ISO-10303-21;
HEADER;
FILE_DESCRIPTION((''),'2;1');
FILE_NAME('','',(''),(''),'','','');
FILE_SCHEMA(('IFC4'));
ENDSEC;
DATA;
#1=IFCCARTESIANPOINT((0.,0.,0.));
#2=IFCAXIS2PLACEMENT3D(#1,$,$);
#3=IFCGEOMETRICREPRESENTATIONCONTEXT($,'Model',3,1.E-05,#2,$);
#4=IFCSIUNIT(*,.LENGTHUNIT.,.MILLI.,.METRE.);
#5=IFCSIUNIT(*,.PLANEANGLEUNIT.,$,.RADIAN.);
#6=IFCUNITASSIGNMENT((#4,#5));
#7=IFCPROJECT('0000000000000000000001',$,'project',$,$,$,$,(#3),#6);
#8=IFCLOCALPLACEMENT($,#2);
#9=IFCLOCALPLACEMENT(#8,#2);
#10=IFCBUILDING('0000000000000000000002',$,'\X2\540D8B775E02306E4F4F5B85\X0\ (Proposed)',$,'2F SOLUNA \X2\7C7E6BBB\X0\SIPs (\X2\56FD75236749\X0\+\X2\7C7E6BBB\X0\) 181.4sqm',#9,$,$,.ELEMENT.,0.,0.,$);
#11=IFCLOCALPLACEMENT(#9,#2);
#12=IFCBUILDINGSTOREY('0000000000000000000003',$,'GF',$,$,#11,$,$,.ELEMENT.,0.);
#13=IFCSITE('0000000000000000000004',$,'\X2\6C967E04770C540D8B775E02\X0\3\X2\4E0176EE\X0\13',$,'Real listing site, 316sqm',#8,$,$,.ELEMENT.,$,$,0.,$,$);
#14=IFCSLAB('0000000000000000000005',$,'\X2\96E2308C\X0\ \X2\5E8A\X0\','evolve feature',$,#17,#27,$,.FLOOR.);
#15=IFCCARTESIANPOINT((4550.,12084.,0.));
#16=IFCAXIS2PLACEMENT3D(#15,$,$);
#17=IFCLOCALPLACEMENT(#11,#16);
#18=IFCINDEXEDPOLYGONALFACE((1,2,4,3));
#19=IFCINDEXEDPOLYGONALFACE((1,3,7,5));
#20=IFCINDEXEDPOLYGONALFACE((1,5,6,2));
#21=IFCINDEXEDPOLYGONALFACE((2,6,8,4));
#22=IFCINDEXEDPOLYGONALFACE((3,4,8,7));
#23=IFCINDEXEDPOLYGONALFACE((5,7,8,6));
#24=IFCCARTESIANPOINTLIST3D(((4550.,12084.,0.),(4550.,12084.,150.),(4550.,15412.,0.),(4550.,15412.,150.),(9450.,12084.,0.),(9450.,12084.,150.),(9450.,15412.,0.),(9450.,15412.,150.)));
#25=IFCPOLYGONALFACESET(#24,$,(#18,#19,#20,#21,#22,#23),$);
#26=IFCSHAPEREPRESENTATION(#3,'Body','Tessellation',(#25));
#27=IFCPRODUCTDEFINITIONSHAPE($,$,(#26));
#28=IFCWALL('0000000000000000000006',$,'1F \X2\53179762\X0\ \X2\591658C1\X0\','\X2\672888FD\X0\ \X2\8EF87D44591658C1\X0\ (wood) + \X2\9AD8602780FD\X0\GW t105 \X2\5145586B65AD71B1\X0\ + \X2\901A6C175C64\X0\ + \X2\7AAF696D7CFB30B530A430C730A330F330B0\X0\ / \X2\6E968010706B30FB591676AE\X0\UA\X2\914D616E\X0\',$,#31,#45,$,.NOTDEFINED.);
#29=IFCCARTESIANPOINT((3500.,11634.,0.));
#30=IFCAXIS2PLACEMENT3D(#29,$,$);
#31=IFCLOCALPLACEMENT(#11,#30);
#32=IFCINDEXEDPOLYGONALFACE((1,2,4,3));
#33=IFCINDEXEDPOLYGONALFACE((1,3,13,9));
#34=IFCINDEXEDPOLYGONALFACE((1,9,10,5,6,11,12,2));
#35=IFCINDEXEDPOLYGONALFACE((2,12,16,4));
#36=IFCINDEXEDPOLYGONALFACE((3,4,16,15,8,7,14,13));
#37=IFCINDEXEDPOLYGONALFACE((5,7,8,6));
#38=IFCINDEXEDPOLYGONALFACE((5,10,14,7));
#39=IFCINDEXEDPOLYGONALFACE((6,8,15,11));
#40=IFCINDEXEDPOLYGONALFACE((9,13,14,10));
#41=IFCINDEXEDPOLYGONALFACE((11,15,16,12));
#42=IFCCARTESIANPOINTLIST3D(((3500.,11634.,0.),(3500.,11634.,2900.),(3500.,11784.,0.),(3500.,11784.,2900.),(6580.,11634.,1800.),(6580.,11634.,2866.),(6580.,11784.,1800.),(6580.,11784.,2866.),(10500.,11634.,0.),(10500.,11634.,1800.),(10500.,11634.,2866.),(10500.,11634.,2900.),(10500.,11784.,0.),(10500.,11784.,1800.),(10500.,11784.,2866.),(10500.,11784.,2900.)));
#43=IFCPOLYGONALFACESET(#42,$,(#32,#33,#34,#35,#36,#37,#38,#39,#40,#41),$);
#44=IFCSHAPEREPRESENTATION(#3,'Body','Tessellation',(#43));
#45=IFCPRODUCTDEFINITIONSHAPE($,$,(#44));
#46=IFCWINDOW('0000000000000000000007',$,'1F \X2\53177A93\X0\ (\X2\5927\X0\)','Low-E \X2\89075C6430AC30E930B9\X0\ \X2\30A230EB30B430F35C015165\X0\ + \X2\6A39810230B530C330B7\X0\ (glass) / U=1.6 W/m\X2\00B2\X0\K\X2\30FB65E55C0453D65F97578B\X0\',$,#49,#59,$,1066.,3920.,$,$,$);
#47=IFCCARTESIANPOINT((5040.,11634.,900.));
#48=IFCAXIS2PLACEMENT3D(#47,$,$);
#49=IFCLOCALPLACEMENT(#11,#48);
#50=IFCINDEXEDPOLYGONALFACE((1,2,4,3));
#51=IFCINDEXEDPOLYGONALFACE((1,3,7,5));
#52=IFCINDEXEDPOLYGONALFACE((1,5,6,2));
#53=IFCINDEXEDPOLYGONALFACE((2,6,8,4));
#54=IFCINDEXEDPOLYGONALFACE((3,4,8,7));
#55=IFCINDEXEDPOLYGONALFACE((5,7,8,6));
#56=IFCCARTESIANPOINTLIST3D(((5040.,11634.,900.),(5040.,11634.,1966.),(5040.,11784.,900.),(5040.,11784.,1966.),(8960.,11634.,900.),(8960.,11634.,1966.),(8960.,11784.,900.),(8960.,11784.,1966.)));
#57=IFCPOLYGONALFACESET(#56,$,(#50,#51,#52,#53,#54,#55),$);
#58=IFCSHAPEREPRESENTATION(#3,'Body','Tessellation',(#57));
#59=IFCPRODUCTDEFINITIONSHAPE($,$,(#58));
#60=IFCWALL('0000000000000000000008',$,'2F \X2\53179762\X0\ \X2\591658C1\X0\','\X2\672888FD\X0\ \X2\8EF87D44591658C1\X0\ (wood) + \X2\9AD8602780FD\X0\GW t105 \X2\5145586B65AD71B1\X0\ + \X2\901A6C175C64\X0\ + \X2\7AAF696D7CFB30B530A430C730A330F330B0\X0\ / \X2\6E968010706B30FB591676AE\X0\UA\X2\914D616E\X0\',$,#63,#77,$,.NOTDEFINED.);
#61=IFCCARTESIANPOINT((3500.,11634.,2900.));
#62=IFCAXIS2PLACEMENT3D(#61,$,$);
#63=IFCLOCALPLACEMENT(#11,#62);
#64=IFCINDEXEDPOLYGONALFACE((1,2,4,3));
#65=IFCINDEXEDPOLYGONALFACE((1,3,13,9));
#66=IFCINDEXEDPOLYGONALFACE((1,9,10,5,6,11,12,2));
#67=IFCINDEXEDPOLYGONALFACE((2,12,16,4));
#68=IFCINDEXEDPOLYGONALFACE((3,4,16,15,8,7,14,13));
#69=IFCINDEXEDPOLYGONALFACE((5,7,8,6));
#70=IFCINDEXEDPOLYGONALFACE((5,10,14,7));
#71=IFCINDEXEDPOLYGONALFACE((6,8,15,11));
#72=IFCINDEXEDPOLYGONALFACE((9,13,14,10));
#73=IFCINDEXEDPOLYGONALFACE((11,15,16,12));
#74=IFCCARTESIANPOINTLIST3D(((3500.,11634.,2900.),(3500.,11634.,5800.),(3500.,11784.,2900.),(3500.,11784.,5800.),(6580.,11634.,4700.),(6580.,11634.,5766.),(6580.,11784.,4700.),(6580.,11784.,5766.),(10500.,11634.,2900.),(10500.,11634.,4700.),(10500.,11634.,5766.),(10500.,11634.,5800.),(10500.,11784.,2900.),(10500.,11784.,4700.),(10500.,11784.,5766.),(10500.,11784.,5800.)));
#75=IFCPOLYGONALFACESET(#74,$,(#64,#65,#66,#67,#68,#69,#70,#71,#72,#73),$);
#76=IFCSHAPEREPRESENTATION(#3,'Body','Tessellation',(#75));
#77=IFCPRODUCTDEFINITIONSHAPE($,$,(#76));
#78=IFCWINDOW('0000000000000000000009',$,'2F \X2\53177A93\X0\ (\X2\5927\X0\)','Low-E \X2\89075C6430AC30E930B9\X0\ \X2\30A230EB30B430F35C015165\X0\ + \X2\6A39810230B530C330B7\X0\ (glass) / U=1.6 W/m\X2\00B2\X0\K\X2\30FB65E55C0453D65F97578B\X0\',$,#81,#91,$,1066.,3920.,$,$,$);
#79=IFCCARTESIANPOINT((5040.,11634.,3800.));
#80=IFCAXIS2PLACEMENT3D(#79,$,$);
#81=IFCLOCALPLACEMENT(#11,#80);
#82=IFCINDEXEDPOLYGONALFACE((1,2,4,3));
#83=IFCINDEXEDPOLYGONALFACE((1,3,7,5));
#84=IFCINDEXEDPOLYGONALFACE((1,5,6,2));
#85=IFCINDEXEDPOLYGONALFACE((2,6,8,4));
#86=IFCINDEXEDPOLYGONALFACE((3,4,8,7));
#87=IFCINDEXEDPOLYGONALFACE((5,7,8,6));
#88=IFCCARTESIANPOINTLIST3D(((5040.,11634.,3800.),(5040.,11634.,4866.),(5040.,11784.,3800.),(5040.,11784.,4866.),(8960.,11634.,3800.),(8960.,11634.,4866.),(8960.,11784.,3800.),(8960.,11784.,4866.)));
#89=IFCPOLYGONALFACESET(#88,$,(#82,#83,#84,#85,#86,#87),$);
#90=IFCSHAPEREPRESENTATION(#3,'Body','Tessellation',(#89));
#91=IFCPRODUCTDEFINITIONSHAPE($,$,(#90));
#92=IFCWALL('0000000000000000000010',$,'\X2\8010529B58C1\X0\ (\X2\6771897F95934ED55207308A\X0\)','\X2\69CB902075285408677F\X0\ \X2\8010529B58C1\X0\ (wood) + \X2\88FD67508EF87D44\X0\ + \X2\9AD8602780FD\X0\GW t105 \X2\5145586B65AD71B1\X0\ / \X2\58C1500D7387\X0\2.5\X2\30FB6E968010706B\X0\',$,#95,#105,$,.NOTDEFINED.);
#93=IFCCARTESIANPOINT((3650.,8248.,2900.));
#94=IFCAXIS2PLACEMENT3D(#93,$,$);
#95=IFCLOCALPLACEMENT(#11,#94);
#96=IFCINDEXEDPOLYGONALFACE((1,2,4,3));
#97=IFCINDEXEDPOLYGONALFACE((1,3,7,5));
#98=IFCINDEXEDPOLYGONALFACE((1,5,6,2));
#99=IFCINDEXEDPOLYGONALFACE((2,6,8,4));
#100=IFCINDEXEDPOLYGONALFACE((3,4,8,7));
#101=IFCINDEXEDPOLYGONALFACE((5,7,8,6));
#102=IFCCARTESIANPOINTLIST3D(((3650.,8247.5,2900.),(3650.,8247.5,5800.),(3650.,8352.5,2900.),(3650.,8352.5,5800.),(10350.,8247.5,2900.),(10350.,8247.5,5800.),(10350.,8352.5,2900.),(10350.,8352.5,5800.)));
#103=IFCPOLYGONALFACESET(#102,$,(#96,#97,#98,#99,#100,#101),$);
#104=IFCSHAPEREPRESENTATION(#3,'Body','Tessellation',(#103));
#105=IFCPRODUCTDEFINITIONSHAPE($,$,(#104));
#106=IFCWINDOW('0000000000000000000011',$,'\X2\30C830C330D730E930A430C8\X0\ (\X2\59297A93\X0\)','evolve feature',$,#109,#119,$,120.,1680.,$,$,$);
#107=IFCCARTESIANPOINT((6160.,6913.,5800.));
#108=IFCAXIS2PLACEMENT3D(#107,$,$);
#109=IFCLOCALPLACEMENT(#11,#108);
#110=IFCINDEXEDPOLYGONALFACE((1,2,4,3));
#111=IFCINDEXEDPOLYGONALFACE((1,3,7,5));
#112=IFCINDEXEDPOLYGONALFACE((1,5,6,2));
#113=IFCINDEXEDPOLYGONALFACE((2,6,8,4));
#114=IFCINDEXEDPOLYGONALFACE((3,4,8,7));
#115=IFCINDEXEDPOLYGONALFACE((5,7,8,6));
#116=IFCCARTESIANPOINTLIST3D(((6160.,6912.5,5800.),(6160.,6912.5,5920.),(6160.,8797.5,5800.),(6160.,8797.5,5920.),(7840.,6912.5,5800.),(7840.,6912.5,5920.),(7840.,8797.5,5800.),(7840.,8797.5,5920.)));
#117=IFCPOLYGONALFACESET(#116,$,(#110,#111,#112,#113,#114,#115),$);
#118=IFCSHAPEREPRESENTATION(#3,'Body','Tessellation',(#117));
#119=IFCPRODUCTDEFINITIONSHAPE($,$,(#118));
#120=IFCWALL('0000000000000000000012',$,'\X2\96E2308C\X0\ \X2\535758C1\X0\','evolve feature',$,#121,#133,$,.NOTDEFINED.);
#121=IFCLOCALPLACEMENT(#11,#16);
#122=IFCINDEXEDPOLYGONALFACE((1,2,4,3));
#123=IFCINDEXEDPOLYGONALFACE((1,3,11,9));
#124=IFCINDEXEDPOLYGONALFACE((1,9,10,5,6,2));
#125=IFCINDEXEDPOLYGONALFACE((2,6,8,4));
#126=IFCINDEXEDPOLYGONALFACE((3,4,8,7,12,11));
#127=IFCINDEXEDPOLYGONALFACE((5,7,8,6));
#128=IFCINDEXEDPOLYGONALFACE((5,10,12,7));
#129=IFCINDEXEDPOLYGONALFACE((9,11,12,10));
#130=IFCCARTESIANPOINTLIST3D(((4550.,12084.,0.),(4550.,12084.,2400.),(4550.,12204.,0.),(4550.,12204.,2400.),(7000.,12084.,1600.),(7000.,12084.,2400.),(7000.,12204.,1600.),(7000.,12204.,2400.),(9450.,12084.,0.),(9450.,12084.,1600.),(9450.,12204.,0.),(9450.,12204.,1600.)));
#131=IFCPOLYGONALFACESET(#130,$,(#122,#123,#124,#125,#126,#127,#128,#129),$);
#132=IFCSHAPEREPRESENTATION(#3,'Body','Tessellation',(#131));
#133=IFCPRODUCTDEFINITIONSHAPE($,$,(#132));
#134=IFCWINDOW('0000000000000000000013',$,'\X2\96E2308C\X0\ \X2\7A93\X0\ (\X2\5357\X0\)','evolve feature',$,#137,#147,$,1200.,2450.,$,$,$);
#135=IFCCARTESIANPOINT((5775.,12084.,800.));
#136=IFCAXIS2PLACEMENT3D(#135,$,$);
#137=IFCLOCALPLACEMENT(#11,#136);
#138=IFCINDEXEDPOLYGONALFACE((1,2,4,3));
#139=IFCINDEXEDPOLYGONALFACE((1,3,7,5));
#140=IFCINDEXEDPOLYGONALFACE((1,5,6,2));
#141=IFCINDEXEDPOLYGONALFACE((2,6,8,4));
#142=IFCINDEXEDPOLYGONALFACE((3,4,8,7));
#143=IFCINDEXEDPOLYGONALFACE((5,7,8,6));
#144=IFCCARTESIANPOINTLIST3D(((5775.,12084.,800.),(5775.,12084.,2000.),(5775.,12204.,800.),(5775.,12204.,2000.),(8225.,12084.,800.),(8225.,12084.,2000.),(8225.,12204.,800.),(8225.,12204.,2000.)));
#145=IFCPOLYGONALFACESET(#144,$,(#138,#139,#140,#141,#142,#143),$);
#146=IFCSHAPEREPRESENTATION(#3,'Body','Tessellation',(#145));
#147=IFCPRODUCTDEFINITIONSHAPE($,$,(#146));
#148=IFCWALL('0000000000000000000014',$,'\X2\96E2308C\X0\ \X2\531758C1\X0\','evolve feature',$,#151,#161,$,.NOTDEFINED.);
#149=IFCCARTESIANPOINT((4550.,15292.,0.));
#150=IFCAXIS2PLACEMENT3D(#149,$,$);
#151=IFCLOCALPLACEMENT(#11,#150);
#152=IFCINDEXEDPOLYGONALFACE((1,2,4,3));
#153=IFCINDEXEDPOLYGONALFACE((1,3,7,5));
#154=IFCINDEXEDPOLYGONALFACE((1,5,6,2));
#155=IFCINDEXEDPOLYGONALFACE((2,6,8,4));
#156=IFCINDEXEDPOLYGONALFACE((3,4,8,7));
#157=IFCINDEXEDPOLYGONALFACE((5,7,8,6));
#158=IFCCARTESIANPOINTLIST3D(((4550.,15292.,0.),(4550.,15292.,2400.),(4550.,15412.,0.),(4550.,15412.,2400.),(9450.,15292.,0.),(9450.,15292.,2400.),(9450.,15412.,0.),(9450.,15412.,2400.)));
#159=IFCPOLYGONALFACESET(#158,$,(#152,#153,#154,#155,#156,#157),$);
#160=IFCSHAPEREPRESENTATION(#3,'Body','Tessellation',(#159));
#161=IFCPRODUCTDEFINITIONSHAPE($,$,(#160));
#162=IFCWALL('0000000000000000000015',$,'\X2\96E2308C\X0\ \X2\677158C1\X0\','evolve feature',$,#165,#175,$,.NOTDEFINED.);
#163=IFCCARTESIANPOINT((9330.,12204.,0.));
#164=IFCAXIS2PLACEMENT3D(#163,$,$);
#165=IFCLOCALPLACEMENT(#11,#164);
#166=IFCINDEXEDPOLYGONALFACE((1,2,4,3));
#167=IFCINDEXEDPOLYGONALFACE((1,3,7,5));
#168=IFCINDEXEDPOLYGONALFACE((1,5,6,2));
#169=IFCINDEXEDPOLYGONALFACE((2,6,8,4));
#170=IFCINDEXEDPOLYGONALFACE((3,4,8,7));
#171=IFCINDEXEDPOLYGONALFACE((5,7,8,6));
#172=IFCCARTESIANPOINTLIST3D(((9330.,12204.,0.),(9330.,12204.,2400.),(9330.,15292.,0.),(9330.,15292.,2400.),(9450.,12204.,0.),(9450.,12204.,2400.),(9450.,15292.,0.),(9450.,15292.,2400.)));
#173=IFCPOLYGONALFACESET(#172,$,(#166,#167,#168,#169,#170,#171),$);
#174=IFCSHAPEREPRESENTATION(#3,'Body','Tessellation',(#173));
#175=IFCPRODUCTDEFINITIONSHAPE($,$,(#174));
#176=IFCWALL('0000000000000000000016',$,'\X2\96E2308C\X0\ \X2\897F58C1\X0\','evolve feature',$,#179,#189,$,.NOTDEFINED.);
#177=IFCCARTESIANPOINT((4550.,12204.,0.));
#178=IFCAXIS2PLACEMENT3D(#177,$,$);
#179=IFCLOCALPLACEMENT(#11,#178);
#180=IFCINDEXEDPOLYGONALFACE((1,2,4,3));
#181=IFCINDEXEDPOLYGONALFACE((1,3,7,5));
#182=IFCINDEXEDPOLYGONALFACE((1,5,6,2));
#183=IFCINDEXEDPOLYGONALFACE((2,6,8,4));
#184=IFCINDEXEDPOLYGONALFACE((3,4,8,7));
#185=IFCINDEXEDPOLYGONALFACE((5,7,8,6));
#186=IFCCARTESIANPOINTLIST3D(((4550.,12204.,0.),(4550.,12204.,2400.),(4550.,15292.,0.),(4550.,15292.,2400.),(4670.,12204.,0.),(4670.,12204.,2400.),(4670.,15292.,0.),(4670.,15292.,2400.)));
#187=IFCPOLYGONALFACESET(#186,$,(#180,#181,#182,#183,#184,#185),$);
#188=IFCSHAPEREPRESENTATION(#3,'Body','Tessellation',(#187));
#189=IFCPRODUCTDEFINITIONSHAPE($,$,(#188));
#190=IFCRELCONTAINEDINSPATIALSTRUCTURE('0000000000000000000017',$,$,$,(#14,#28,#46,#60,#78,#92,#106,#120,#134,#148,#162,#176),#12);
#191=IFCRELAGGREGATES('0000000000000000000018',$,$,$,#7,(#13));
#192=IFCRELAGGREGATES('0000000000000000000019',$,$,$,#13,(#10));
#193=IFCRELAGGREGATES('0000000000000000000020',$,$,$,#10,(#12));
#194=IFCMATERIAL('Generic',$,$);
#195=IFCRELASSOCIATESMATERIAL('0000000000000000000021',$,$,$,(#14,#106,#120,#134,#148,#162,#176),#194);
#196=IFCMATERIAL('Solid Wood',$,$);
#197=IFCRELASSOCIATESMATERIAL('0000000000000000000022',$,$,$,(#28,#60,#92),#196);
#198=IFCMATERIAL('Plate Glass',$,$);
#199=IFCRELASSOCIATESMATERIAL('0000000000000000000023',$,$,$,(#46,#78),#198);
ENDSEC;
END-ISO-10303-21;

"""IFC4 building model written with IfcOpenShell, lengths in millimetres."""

from ifc_helpers import new_model, si_unit, frame, frame_2d, origin, place, context, project, spatial, rectangle, extrude, material, element, fill, save


model = new_model("IFC4")

# Units and contexts
model_context = context("Model", 3, precision=1e-05, world=origin())
ifc_project = project(units=[si_unit("LENGTHUNIT", "METRE", prefix="MILLI"), si_unit("PLANEANGLEUNIT", "RADIAN")], contexts=[model_context])

# Site, building, storey
site_placement = place(None, origin())
site = spatial("IfcSite", under=ifc_project, at=site_placement, Name="沖縄県名護市3丁目13", ObjectType="Real listing site, 316sqm", CompositionType="ELEMENT", RefElevation=0.0)
building_placement = place(site_placement, origin())
building = spatial("IfcBuilding", under=site, at=building_placement, Name="名護市の住宅 (Proposed)", ObjectType="2F SOLUNA 籾殻SIPs (国産杉+籾殻) 181.4sqm", CompositionType="ELEMENT", ElevationOfRefHeight=0.0, ElevationOfTerrain=0.0)
storey_placement = place(building_placement, origin())
storey = spatial("IfcBuildingStorey", under=building, at=storey_placement, Name="GF", CompositionType="ELEMENT", Elevation=0.0)

# Slab
ifc_material_1 = material(Name="Generic")
slab_placement = place(storey_placement, frame((4550.0, 12084.0, 0.0)))
element("IfcSlab", 1, at=slab_placement, inside=storey, material=ifc_material_1, Name="離れ 床", Description="evolve feature", PredefinedType="FLOOR", context=model_context, shape_type="SweptSolid", body=[
    extrude(rectangle(XDim=4900.0, YDim=3328.0, at=frame_2d((2450.0, 1664.0))), frame((4550.0, 12084.0, 0.0)), (0.0, 0.0, 1.0), 150.0),
])

# Wall, opening, window
ifc_material_2 = material(Name="Solid Wood")
wall_1_placement = place(storey_placement, frame((3500.0, 11634.0, 0.0)))
wall_1 = element("IfcWall", 2, at=wall_1_placement, inside=storey, material=ifc_material_2, Name="1F 北面 外壁", Description="木製 軸組外壁 (wood) + 高性能GW t105 充填断熱 + 通気層 + 窯業系サイディング / 準耐火・外皮UA配慮", PredefinedType="NOTDEFINED", context=model_context, shape_type="SweptSolid", body=[
    extrude(rectangle(XDim=7000.0, YDim=150.0, at=frame_2d((3500.0, 75.0))), frame((3500.0, 11634.0, 0.0)), (0.0, 0.0, 1.0), 2900.0),
])
opening_1_placement = place(storey_placement, frame((5040.0, 11634.0, 900.0)))
opening_1 = element("IfcOpeningElement", 3, at=opening_1_placement, cuts=wall_1, PredefinedType="NOTDEFINED", context=model_context, shape_type="SweptSolid", body=[
    extrude(rectangle(XDim=3920.0, YDim=150.0, at=frame_2d((1960.0, 75.0))), frame((5040.0, 11634.0, 900.0)), (0.0, 0.0, 1.0), 1066.0),
])
ifc_material_3 = material(Name="Plate Glass")
window_1_placement = place(storey_placement, frame((5040.0, 11634.0, 900.0)))
window_1 = element("IfcWindow", 4, at=window_1_placement, inside=storey, material=ifc_material_3, Name="1F 北窓 (大)", Description="Low-E 複層ガラス アルゴン封入 + 樹脂サッシ (glass) / U=1.6 W/m²K・日射取得型", OverallHeight=1066.0, OverallWidth=3920.0, context=model_context, shape_type="SweptSolid", body=[
    extrude(rectangle(XDim=3920.0, YDim=150.0, at=frame_2d((1960.0, 75.0))), frame((5040.0, 11634.0, 900.0)), (0.0, 0.0, 1.0), 1066.0),
])
fill(opening_1, window_1)

# Wall, opening, window
wall_2_placement = place(storey_placement, frame((3500.0, 11634.0, 2900.0)))
wall_2 = element("IfcWall", 5, at=wall_2_placement, inside=storey, material=ifc_material_2, Name="2F 北面 外壁", Description="木製 軸組外壁 (wood) + 高性能GW t105 充填断熱 + 通気層 + 窯業系サイディング / 準耐火・外皮UA配慮", PredefinedType="NOTDEFINED", context=model_context, shape_type="SweptSolid", body=[
    extrude(rectangle(XDim=7000.0, YDim=150.0, at=frame_2d((3500.0, 75.0))), frame((3500.0, 11634.0, 2900.0)), (0.0, 0.0, 1.0), 2900.0),
])
opening_2_placement = place(storey_placement, frame((5040.0, 11634.0, 3800.0)))
opening_2 = element("IfcOpeningElement", 6, at=opening_2_placement, cuts=wall_2, PredefinedType="NOTDEFINED", context=model_context, shape_type="SweptSolid", body=[
    extrude(rectangle(XDim=3920.0, YDim=150.0, at=frame_2d((1960.0, 75.0))), frame((5040.0, 11634.0, 3800.0)), (0.0, 0.0, 1.0), 1066.0),
])
window_2_placement = place(storey_placement, frame((5040.0, 11634.0, 3800.0)))
window_2 = element("IfcWindow", 7, at=window_2_placement, inside=storey, material=ifc_material_3, Name="2F 北窓 (大)", Description="Low-E 複層ガラス アルゴン封入 + 樹脂サッシ (glass) / U=1.6 W/m²K・日射取得型", OverallHeight=1066.0, OverallWidth=3920.0, context=model_context, shape_type="SweptSolid", body=[
    extrude(rectangle(XDim=3920.0, YDim=150.0, at=frame_2d((1960.0, 75.0))), frame((5040.0, 11634.0, 3800.0)), (0.0, 0.0, 1.0), 1066.0),
])
fill(opening_2, window_2)

# Wall
wall_3_placement = place(storey_placement, frame((3650.0, 8248.0, 2900.0)))
element("IfcWall", 8, at=wall_3_placement, inside=storey, material=ifc_material_2, Name="耐力壁 (東西間仕切り)", Description="構造用合板 耐力壁 (wood) + 製材軸組 + 高性能GW t105 充填断熱 / 壁倍率2.5・準耐火", PredefinedType="NOTDEFINED", context=model_context, shape_type="SweptSolid", body=[
    extrude(rectangle(XDim=6700.0, YDim=105.0, at=frame_2d((3350.0, 52.0))), frame((3650.0, 8248.0, 2900.0)), (0.0, 0.0, 1.0), 2900.0),
])

# Window
window_3_placement = place(storey_placement, frame((6160.0, 6913.0, 5800.0)))
element("IfcWindow", 9, at=window_3_placement, inside=storey, material=ifc_material_1, Name="トップライト (天窓)", Description="evolve feature", OverallHeight=120.0, OverallWidth=1680.0, context=model_context, shape_type="SweptSolid", body=[
    extrude(rectangle(XDim=1680.0, YDim=1885.0, at=frame_2d((840.0, 942.0))), frame((6160.0, 6913.0, 5800.0)), (0.0, 0.0, 1.0), 120.0),
])

# Wall, opening, window
wall_4_placement = place(storey_placement, frame((4550.0, 12084.0, 0.0)))
wall_4 = element("IfcWall", 10, at=wall_4_placement, inside=storey, material=ifc_material_1, Name="離れ 南壁", Description="evolve feature", PredefinedType="NOTDEFINED", context=model_context, shape_type="SweptSolid", body=[
    extrude(rectangle(XDim=4900.0, YDim=120.0, at=frame_2d((2450.0, 60.0))), frame((4550.0, 12084.0, 0.0)), (0.0, 0.0, 1.0), 2400.0),
])
opening_3_placement = place(storey_placement, frame((5775.0, 12084.0, 800.0)))
opening_3 = element("IfcOpeningElement", 11, at=opening_3_placement, cuts=wall_4, PredefinedType="NOTDEFINED", context=model_context, shape_type="SweptSolid", body=[
    extrude(rectangle(XDim=2450.0, YDim=120.0, at=frame_2d((1225.0, 60.0))), frame((5775.0, 12084.0, 800.0)), (0.0, 0.0, 1.0), 1200.0),
])
window_4_placement = place(storey_placement, frame((5775.0, 12084.0, 800.0)))
window_4 = element("IfcWindow", 12, at=window_4_placement, inside=storey, material=ifc_material_1, Name="離れ 窓 (南)", Description="evolve feature", OverallHeight=1200.0, OverallWidth=2450.0, context=model_context, shape_type="SweptSolid", body=[
    extrude(rectangle(XDim=2450.0, YDim=120.0, at=frame_2d((1225.0, 60.0))), frame((5775.0, 12084.0, 800.0)), (0.0, 0.0, 1.0), 1200.0),
])
fill(opening_3, window_4)

# Walls
wall_5_placement = place(storey_placement, frame((4550.0, 15292.0, 0.0)))
element("IfcWall", 13, at=wall_5_placement, inside=storey, material=ifc_material_1, Name="離れ 北壁", Description="evolve feature", PredefinedType="NOTDEFINED", context=model_context, shape_type="SweptSolid", body=[
    extrude(rectangle(XDim=4900.0, YDim=120.0, at=frame_2d((2450.0, 60.0))), frame((4550.0, 15292.0, 0.0)), (0.0, 0.0, 1.0), 2400.0),
])
wall_6_placement = place(storey_placement, frame((9330.0, 12204.0, 0.0)))
element("IfcWall", 14, at=wall_6_placement, inside=storey, material=ifc_material_1, Name="離れ 東壁", Description="evolve feature", PredefinedType="NOTDEFINED", context=model_context, shape_type="SweptSolid", body=[
    extrude(rectangle(XDim=120.0, YDim=3088.0, at=frame_2d((60.0, 1544.0))), frame((9330.0, 12204.0, 0.0)), (0.0, 0.0, 1.0), 2400.0),
])
wall_7_placement = place(storey_placement, frame((4550.0, 12204.0, 0.0)))
element("IfcWall", 15, at=wall_7_placement, inside=storey, material=ifc_material_1, Name="離れ 西壁", Description="evolve feature", PredefinedType="NOTDEFINED", context=model_context, shape_type="SweptSolid", body=[
    extrude(rectangle(XDim=120.0, YDim=3088.0, at=frame_2d((60.0, 1544.0))), frame((4550.0, 12204.0, 0.0)), (0.0, 0.0, 1.0), 2400.0),
])

save(model, "model.ifc")
